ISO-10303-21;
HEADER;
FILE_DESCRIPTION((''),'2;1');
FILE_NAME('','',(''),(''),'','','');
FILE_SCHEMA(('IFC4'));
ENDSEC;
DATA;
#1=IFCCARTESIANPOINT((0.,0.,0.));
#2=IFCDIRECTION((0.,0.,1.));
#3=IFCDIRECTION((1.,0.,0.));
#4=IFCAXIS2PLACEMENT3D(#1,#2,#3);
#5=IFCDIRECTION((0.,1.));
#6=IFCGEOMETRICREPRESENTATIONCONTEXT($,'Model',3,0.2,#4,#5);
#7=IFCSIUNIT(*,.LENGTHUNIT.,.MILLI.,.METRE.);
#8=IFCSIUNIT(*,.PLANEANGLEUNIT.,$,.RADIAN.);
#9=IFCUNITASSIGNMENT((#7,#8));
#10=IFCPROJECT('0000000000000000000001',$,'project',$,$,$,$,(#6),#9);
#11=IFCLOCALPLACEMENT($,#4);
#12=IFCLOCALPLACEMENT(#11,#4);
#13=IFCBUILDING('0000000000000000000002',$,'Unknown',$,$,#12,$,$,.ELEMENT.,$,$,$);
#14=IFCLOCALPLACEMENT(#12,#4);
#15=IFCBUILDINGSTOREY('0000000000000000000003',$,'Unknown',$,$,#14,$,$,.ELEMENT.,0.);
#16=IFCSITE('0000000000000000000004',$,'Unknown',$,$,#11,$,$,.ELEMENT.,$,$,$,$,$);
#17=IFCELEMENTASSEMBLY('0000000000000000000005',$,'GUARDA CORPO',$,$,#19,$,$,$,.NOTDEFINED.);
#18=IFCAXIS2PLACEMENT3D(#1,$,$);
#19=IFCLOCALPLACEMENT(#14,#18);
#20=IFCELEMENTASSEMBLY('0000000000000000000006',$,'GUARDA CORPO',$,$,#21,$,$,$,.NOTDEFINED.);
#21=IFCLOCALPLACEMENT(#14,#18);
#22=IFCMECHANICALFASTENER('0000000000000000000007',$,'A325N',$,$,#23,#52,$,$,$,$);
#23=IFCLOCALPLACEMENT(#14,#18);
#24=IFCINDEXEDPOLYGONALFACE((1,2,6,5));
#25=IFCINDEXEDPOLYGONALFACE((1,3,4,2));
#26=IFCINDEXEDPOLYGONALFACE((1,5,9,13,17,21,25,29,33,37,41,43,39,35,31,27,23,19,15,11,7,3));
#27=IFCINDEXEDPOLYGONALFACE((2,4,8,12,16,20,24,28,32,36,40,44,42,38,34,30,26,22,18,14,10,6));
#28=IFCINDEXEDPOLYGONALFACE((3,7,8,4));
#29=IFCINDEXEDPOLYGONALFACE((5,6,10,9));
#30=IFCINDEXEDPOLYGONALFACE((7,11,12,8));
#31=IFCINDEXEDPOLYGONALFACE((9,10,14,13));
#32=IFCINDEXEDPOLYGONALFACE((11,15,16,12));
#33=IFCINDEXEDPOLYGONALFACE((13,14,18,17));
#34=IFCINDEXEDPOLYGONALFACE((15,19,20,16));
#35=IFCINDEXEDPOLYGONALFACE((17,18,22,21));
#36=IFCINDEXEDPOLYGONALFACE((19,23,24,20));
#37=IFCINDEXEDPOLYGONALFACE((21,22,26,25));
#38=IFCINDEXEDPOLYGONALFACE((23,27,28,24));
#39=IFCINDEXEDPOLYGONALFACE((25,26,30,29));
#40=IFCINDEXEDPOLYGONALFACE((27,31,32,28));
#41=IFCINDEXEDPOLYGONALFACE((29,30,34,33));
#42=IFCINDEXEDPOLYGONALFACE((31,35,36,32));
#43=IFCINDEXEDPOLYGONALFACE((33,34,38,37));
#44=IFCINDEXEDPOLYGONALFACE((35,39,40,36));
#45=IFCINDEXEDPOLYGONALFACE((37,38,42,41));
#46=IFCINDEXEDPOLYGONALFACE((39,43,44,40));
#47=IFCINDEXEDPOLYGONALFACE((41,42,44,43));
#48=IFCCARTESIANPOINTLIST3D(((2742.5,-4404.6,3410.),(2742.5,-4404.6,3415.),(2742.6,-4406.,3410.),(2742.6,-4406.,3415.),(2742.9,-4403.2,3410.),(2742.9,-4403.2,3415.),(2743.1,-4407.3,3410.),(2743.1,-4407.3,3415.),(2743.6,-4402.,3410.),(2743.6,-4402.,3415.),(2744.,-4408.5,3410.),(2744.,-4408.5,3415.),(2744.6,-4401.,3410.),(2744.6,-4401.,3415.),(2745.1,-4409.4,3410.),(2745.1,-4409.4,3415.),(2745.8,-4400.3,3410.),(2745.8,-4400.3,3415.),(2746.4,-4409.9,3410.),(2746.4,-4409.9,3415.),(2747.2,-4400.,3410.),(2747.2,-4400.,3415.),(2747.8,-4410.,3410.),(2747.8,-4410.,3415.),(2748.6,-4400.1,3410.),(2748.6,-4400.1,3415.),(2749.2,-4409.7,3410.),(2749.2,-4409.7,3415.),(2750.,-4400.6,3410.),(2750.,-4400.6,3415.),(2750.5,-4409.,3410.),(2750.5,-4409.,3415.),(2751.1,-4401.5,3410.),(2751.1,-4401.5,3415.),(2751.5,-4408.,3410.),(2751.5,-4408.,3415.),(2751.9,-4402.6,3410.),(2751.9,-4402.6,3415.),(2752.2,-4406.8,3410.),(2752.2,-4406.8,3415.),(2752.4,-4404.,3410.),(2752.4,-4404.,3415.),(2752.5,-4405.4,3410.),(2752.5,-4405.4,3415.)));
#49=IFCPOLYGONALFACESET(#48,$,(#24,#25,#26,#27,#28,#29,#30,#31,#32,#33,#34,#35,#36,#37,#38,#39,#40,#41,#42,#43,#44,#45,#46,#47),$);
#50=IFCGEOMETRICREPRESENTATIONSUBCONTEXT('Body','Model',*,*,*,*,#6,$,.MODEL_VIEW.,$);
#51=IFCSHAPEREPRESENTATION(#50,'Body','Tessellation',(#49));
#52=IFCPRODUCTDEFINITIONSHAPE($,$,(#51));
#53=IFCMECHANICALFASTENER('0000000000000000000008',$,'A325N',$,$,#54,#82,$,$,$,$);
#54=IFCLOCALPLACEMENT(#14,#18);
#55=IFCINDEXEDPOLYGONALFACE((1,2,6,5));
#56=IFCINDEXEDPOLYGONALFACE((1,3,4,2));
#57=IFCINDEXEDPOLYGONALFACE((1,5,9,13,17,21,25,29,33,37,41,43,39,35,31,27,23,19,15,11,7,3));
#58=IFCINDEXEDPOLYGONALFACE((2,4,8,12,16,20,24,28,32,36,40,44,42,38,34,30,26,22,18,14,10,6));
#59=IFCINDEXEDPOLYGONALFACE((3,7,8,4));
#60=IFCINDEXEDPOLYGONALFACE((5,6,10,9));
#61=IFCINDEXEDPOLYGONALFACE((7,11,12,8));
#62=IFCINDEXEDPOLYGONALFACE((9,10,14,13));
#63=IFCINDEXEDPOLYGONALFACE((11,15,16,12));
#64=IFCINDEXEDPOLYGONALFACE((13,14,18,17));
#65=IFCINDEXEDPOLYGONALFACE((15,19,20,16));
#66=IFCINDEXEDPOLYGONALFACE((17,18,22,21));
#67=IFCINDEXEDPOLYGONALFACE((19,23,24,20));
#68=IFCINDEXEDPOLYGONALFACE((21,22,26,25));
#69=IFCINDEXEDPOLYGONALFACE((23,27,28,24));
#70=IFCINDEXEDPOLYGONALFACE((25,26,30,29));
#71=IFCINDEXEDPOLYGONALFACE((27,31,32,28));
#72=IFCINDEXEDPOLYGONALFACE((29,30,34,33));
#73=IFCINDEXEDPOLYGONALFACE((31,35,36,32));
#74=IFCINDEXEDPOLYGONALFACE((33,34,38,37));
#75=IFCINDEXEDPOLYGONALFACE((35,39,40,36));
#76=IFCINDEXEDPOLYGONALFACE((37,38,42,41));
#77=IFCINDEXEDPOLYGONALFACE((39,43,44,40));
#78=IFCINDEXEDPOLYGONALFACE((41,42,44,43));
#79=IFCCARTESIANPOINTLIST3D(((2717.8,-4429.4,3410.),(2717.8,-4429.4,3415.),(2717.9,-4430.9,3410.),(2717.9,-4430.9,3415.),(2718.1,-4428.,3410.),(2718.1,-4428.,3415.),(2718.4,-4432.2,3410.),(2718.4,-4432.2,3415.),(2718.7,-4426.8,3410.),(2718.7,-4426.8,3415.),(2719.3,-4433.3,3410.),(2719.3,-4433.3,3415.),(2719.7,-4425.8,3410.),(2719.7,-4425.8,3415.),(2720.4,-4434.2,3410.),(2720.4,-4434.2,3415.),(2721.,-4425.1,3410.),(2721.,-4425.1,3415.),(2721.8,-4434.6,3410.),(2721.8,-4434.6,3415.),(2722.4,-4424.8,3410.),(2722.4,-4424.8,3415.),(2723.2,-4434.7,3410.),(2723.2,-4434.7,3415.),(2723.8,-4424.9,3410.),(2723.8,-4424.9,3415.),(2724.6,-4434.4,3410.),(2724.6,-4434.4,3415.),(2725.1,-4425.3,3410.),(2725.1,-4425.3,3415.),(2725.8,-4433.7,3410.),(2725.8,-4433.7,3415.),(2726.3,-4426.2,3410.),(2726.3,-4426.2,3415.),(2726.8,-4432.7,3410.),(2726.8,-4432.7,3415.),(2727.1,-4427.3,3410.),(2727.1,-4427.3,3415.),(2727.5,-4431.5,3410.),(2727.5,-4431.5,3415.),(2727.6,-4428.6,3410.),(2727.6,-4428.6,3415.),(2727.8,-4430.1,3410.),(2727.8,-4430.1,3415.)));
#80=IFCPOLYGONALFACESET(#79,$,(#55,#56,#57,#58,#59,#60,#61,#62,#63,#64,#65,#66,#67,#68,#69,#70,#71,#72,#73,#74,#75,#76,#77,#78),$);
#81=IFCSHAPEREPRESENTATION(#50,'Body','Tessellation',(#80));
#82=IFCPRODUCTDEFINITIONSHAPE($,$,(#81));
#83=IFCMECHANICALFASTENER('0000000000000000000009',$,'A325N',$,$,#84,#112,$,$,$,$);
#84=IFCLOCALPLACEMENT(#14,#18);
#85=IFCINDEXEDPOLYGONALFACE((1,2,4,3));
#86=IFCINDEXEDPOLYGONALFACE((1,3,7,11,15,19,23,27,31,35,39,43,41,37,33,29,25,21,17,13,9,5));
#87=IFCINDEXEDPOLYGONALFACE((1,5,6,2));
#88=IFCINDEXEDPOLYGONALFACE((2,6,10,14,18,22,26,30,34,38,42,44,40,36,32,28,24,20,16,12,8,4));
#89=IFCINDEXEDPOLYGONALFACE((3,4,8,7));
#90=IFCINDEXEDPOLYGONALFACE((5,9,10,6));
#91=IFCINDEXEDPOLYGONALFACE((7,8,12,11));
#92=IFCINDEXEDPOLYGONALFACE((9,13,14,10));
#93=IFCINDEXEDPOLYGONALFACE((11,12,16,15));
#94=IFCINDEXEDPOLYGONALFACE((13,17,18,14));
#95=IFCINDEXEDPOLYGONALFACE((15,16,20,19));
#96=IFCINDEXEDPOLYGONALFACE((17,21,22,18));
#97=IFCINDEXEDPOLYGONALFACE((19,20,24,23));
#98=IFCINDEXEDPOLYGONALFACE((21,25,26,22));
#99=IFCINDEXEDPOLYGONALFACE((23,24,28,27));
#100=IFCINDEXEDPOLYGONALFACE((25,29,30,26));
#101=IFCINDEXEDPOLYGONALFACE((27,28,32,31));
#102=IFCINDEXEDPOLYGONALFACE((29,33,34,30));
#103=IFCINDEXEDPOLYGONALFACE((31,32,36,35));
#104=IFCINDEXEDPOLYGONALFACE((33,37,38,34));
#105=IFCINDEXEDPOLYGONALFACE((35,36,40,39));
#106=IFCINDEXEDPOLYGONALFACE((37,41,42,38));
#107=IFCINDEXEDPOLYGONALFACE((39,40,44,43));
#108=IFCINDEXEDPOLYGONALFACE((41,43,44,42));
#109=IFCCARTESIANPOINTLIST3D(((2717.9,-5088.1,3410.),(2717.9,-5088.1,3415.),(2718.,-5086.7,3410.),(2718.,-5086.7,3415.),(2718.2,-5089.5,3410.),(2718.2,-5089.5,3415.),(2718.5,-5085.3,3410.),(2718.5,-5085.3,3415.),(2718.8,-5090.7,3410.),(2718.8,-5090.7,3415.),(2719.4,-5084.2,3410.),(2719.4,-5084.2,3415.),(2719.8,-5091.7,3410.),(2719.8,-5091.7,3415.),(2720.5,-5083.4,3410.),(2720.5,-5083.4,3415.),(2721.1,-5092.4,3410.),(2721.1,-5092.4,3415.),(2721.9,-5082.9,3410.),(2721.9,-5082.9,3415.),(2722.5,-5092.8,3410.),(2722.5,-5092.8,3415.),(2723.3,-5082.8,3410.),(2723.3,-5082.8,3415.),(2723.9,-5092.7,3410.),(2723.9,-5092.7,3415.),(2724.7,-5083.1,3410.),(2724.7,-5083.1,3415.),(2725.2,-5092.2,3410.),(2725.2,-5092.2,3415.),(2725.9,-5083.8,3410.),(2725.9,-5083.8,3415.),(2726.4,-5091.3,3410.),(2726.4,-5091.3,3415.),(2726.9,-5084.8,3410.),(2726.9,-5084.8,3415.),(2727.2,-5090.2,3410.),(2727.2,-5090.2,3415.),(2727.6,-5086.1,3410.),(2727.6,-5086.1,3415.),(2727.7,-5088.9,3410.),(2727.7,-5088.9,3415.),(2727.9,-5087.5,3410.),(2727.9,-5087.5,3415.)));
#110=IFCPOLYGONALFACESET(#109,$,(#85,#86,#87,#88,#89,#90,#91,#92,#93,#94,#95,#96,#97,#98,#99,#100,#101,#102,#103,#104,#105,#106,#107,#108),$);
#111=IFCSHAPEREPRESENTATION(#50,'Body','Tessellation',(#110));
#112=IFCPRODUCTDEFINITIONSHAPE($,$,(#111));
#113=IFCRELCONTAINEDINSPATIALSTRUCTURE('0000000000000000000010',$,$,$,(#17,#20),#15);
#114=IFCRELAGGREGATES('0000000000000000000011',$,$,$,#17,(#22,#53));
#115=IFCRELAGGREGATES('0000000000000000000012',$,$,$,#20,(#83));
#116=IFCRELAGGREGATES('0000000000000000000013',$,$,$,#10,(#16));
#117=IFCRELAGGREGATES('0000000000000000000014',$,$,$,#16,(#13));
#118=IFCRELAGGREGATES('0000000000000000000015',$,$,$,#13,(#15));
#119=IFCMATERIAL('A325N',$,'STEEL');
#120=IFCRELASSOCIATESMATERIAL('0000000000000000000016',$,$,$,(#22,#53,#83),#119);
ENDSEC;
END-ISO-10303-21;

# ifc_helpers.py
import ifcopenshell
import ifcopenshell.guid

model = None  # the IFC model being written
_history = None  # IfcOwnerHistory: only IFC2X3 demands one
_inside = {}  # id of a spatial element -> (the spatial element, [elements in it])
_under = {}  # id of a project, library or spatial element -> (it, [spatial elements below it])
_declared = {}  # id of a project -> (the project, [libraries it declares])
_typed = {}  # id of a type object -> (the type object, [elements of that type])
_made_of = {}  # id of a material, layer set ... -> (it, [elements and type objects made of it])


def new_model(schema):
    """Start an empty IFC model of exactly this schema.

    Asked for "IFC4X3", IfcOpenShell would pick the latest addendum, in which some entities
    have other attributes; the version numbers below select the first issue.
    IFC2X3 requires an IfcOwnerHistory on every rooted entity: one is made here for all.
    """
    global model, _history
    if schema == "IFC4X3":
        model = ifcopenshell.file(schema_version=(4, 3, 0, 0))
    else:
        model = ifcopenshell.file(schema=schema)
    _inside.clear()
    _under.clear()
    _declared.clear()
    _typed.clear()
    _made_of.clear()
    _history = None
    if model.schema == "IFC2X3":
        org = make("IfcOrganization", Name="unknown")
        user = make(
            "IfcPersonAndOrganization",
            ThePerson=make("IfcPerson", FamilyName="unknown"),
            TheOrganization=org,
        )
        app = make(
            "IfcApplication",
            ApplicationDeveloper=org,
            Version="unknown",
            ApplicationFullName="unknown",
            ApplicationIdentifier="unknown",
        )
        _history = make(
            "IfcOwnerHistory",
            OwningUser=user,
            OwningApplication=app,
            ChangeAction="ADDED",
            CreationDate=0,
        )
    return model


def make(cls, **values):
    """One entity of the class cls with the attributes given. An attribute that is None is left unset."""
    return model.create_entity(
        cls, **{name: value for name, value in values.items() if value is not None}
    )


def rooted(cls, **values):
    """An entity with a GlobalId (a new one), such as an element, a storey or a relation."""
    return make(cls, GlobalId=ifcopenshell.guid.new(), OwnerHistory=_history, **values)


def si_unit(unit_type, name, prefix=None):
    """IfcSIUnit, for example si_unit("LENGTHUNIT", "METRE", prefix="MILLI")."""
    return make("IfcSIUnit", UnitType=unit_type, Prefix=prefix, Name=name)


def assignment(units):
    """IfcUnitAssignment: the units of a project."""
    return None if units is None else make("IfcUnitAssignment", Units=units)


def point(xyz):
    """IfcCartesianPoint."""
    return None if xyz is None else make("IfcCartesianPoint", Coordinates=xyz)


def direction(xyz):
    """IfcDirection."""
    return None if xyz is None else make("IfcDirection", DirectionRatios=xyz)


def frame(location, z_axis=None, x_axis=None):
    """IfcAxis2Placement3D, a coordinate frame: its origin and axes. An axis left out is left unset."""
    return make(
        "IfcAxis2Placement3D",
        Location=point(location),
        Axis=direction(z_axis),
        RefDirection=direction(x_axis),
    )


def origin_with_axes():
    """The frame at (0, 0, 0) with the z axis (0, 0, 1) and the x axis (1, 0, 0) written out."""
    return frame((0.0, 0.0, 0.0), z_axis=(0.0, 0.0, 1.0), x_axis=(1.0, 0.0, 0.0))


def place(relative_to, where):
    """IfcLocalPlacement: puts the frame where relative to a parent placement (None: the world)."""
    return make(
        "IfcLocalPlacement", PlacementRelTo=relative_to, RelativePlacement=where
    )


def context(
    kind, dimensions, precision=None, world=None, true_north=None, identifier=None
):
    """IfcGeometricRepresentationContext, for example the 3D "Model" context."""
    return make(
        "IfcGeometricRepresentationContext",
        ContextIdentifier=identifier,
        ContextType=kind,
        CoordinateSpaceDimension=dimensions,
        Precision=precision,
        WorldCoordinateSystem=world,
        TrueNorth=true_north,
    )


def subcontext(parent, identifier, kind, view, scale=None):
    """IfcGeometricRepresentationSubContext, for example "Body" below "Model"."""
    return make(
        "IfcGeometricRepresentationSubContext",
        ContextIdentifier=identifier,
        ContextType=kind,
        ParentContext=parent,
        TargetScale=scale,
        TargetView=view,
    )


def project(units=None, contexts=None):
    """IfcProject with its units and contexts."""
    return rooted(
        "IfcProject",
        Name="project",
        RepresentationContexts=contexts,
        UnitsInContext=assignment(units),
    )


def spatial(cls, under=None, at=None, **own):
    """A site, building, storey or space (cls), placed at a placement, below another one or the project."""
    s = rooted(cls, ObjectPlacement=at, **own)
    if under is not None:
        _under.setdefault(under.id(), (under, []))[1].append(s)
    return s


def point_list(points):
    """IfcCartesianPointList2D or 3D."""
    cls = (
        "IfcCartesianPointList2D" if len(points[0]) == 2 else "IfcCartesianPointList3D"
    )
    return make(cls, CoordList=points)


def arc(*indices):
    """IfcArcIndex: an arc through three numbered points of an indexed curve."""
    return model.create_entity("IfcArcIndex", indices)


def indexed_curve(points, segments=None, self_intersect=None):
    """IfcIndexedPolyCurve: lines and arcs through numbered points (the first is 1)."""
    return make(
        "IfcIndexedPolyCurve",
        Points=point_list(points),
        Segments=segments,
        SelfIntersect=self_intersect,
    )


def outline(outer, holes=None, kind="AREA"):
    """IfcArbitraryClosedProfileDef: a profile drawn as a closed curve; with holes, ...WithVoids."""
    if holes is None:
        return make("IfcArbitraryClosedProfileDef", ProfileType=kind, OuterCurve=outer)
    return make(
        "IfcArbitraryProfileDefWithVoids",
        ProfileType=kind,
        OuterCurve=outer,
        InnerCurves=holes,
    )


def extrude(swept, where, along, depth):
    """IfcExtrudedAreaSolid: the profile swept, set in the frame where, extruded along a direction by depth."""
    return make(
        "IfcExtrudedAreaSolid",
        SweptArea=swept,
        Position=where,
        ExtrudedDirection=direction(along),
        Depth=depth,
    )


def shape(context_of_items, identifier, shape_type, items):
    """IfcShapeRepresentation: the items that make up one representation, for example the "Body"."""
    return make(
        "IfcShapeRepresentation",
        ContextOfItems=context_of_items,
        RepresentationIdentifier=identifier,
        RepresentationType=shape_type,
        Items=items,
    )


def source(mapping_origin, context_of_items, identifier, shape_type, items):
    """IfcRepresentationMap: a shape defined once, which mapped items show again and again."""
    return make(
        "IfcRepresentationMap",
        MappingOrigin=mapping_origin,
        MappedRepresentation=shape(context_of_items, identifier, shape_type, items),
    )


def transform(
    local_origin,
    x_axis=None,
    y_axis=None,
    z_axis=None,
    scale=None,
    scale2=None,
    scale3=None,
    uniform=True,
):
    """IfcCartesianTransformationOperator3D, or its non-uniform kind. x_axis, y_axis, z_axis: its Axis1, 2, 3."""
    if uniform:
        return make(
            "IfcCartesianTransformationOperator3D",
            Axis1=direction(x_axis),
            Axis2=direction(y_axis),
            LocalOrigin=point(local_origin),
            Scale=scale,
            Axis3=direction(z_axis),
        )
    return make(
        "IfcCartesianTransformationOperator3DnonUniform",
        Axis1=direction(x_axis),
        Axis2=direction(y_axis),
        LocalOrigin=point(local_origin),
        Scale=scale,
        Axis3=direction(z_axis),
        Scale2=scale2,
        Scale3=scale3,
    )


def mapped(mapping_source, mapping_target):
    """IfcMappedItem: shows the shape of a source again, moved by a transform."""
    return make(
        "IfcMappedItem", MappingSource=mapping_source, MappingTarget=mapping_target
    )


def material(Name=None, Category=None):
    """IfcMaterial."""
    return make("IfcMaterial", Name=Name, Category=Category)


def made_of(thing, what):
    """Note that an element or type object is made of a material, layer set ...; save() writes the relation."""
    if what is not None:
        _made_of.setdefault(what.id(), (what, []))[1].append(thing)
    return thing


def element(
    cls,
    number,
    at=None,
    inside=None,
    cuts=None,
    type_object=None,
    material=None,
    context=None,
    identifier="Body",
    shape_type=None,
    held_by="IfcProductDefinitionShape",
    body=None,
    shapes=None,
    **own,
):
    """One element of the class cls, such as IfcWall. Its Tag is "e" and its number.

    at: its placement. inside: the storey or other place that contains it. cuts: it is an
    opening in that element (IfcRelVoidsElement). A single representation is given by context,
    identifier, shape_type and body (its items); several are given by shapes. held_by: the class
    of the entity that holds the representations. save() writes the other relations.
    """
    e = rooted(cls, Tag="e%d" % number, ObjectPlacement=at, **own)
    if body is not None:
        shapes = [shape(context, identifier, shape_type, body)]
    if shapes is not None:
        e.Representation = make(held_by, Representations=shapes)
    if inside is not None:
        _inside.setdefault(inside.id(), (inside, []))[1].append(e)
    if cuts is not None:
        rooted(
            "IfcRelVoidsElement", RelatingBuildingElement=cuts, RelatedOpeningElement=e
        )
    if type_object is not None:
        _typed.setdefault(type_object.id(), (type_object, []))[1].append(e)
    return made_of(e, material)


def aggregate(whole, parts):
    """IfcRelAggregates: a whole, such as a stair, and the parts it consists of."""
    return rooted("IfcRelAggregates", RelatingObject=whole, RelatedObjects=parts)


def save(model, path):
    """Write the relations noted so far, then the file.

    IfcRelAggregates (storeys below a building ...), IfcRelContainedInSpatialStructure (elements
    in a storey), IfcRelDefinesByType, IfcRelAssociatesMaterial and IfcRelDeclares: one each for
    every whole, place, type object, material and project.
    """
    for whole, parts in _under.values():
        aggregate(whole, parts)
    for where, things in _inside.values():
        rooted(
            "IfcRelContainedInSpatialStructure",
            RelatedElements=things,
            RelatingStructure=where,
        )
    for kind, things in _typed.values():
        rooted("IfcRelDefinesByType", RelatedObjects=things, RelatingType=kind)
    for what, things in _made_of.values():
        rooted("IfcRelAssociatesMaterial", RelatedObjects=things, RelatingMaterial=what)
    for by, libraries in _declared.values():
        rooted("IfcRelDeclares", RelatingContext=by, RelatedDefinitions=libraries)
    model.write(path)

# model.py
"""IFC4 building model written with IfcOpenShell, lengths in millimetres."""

from ifc_helpers import new_model, si_unit, direction, frame, origin_with_axes, place, context, subcontext, project, spatial, arc, indexed_curve, outline, extrude, source, transform, mapped, material, element, aggregate, save


model = new_model("IFC4")

# Units and contexts
model_context = context("Model", 3, precision=0.2, world=origin_with_axes(), true_north=direction((0.0, 1.0)))
body_context = subcontext(model_context, "Body", "Model", "MODEL_VIEW")
ifc_project = project(units=[si_unit("LENGTHUNIT", "METRE", prefix="MILLI"), si_unit("PLANEANGLEUNIT", "RADIAN")], contexts=[model_context])

# Site, building, storey
site_placement = place(None, origin_with_axes())
site = spatial("IfcSite", under=ifc_project, at=site_placement, Name="Unknown", CompositionType="ELEMENT")
building_placement = place(site_placement, origin_with_axes())
building = spatial("IfcBuilding", under=site, at=building_placement, Name="Unknown", CompositionType="ELEMENT")
storey_placement = place(building_placement, origin_with_axes())
storey = spatial("IfcBuildingStorey", under=building, at=storey_placement, Name="Unknown", CompositionType="ELEMENT", Elevation=0.0)

# Element assembly
assembly_1_placement = place(storey_placement, frame((2747.5, -4429.7, 3415.0), z_axis=(-0.000512, -1.0, -0.000003), x_axis=(0.000003, -0.000003, 1.0)))
assembly_1 = element("IfcElementAssembly", 1, at=assembly_1_placement, inside=storey, Name="GUARDA CORPO", PredefinedType="NOTDEFINED")

# Element assembly
assembly_2_placement = place(storey_placement, frame((2747.5, -5087.8, 3415.0), z_axis=(-1.0, 0.000512, 0.000003), x_axis=(0.000003, 0.000003, 1.0)))
assembly_2 = element("IfcElementAssembly", 2, at=assembly_2_placement, inside=storey, Name="GUARDA CORPO", PredefinedType="NOTDEFINED")

# Mechanical fasteners
ifc_material_1 = material(Name="A325N", Category="STEEL")
shared_shape_1 = source(origin_with_axes(), body_context, "Body", "SweptSolid", [
    extrude(outline(indexed_curve([(5.0, 0.0), (0.0, 5.0), (-5.0, 0.0), (0.0, -5.0)], segments=[arc(1, 2, 3), arc(3, 4, 1)])), frame((0.0, 0.0, 0.0), z_axis=(0.0, 0.0, -1.0), x_axis=(0.0, 1.0, 0.0)), (0.0, 0.0, 1.0), 5.0),
])
mechanical_fastener_1_placement = place(assembly_1_placement, frame((0.0, 0.0, -24.7), z_axis=(1.0, 0.000004, -0.000004), x_axis=(0.000005, -0.471397, 0.881921)))
mechanical_fastener_1 = element("IfcMechanicalFastener", 3, at=mechanical_fastener_1_placement, material=ifc_material_1, Name="A325N", context=body_context, shape_type="MappedRepresentation", body=[
    mapped(shared_shape_1, transform((0.0, 0.0, 0.0))),
])
mechanical_fastener_2_placement = place(assembly_1_placement, frame((0.0, 24.8, 0.1), z_axis=(1.0, 0.000004, -0.000003), x_axis=(0.000005, -0.882404, 0.470493)))
mechanical_fastener_2 = element("IfcMechanicalFastener", 4, at=mechanical_fastener_2_placement, material=ifc_material_1, Name="A325N", context=body_context, shape_type="MappedRepresentation", body=[
    mapped(shared_shape_1, transform((0.0, 0.0, 0.0))),
])
aggregate(assembly_1, [mechanical_fastener_1, mechanical_fastener_2])
mechanical_fastener_3_placement = place(assembly_2_placement, frame((0.0, 0.0, 24.7), z_axis=(1.0, -0.000004, 0.000004), x_axis=(0.000005, 0.471397, -0.881921)))
mechanical_fastener_3 = element("IfcMechanicalFastener", 5, at=mechanical_fastener_3_placement, material=ifc_material_1, Name="A325N", context=body_context, shape_type="MappedRepresentation", body=[
    mapped(shared_shape_1, transform((0.0, 0.0, 0.0))),
])
aggregate(assembly_2, [mechanical_fastener_3])

save(model, "model.ifc")
